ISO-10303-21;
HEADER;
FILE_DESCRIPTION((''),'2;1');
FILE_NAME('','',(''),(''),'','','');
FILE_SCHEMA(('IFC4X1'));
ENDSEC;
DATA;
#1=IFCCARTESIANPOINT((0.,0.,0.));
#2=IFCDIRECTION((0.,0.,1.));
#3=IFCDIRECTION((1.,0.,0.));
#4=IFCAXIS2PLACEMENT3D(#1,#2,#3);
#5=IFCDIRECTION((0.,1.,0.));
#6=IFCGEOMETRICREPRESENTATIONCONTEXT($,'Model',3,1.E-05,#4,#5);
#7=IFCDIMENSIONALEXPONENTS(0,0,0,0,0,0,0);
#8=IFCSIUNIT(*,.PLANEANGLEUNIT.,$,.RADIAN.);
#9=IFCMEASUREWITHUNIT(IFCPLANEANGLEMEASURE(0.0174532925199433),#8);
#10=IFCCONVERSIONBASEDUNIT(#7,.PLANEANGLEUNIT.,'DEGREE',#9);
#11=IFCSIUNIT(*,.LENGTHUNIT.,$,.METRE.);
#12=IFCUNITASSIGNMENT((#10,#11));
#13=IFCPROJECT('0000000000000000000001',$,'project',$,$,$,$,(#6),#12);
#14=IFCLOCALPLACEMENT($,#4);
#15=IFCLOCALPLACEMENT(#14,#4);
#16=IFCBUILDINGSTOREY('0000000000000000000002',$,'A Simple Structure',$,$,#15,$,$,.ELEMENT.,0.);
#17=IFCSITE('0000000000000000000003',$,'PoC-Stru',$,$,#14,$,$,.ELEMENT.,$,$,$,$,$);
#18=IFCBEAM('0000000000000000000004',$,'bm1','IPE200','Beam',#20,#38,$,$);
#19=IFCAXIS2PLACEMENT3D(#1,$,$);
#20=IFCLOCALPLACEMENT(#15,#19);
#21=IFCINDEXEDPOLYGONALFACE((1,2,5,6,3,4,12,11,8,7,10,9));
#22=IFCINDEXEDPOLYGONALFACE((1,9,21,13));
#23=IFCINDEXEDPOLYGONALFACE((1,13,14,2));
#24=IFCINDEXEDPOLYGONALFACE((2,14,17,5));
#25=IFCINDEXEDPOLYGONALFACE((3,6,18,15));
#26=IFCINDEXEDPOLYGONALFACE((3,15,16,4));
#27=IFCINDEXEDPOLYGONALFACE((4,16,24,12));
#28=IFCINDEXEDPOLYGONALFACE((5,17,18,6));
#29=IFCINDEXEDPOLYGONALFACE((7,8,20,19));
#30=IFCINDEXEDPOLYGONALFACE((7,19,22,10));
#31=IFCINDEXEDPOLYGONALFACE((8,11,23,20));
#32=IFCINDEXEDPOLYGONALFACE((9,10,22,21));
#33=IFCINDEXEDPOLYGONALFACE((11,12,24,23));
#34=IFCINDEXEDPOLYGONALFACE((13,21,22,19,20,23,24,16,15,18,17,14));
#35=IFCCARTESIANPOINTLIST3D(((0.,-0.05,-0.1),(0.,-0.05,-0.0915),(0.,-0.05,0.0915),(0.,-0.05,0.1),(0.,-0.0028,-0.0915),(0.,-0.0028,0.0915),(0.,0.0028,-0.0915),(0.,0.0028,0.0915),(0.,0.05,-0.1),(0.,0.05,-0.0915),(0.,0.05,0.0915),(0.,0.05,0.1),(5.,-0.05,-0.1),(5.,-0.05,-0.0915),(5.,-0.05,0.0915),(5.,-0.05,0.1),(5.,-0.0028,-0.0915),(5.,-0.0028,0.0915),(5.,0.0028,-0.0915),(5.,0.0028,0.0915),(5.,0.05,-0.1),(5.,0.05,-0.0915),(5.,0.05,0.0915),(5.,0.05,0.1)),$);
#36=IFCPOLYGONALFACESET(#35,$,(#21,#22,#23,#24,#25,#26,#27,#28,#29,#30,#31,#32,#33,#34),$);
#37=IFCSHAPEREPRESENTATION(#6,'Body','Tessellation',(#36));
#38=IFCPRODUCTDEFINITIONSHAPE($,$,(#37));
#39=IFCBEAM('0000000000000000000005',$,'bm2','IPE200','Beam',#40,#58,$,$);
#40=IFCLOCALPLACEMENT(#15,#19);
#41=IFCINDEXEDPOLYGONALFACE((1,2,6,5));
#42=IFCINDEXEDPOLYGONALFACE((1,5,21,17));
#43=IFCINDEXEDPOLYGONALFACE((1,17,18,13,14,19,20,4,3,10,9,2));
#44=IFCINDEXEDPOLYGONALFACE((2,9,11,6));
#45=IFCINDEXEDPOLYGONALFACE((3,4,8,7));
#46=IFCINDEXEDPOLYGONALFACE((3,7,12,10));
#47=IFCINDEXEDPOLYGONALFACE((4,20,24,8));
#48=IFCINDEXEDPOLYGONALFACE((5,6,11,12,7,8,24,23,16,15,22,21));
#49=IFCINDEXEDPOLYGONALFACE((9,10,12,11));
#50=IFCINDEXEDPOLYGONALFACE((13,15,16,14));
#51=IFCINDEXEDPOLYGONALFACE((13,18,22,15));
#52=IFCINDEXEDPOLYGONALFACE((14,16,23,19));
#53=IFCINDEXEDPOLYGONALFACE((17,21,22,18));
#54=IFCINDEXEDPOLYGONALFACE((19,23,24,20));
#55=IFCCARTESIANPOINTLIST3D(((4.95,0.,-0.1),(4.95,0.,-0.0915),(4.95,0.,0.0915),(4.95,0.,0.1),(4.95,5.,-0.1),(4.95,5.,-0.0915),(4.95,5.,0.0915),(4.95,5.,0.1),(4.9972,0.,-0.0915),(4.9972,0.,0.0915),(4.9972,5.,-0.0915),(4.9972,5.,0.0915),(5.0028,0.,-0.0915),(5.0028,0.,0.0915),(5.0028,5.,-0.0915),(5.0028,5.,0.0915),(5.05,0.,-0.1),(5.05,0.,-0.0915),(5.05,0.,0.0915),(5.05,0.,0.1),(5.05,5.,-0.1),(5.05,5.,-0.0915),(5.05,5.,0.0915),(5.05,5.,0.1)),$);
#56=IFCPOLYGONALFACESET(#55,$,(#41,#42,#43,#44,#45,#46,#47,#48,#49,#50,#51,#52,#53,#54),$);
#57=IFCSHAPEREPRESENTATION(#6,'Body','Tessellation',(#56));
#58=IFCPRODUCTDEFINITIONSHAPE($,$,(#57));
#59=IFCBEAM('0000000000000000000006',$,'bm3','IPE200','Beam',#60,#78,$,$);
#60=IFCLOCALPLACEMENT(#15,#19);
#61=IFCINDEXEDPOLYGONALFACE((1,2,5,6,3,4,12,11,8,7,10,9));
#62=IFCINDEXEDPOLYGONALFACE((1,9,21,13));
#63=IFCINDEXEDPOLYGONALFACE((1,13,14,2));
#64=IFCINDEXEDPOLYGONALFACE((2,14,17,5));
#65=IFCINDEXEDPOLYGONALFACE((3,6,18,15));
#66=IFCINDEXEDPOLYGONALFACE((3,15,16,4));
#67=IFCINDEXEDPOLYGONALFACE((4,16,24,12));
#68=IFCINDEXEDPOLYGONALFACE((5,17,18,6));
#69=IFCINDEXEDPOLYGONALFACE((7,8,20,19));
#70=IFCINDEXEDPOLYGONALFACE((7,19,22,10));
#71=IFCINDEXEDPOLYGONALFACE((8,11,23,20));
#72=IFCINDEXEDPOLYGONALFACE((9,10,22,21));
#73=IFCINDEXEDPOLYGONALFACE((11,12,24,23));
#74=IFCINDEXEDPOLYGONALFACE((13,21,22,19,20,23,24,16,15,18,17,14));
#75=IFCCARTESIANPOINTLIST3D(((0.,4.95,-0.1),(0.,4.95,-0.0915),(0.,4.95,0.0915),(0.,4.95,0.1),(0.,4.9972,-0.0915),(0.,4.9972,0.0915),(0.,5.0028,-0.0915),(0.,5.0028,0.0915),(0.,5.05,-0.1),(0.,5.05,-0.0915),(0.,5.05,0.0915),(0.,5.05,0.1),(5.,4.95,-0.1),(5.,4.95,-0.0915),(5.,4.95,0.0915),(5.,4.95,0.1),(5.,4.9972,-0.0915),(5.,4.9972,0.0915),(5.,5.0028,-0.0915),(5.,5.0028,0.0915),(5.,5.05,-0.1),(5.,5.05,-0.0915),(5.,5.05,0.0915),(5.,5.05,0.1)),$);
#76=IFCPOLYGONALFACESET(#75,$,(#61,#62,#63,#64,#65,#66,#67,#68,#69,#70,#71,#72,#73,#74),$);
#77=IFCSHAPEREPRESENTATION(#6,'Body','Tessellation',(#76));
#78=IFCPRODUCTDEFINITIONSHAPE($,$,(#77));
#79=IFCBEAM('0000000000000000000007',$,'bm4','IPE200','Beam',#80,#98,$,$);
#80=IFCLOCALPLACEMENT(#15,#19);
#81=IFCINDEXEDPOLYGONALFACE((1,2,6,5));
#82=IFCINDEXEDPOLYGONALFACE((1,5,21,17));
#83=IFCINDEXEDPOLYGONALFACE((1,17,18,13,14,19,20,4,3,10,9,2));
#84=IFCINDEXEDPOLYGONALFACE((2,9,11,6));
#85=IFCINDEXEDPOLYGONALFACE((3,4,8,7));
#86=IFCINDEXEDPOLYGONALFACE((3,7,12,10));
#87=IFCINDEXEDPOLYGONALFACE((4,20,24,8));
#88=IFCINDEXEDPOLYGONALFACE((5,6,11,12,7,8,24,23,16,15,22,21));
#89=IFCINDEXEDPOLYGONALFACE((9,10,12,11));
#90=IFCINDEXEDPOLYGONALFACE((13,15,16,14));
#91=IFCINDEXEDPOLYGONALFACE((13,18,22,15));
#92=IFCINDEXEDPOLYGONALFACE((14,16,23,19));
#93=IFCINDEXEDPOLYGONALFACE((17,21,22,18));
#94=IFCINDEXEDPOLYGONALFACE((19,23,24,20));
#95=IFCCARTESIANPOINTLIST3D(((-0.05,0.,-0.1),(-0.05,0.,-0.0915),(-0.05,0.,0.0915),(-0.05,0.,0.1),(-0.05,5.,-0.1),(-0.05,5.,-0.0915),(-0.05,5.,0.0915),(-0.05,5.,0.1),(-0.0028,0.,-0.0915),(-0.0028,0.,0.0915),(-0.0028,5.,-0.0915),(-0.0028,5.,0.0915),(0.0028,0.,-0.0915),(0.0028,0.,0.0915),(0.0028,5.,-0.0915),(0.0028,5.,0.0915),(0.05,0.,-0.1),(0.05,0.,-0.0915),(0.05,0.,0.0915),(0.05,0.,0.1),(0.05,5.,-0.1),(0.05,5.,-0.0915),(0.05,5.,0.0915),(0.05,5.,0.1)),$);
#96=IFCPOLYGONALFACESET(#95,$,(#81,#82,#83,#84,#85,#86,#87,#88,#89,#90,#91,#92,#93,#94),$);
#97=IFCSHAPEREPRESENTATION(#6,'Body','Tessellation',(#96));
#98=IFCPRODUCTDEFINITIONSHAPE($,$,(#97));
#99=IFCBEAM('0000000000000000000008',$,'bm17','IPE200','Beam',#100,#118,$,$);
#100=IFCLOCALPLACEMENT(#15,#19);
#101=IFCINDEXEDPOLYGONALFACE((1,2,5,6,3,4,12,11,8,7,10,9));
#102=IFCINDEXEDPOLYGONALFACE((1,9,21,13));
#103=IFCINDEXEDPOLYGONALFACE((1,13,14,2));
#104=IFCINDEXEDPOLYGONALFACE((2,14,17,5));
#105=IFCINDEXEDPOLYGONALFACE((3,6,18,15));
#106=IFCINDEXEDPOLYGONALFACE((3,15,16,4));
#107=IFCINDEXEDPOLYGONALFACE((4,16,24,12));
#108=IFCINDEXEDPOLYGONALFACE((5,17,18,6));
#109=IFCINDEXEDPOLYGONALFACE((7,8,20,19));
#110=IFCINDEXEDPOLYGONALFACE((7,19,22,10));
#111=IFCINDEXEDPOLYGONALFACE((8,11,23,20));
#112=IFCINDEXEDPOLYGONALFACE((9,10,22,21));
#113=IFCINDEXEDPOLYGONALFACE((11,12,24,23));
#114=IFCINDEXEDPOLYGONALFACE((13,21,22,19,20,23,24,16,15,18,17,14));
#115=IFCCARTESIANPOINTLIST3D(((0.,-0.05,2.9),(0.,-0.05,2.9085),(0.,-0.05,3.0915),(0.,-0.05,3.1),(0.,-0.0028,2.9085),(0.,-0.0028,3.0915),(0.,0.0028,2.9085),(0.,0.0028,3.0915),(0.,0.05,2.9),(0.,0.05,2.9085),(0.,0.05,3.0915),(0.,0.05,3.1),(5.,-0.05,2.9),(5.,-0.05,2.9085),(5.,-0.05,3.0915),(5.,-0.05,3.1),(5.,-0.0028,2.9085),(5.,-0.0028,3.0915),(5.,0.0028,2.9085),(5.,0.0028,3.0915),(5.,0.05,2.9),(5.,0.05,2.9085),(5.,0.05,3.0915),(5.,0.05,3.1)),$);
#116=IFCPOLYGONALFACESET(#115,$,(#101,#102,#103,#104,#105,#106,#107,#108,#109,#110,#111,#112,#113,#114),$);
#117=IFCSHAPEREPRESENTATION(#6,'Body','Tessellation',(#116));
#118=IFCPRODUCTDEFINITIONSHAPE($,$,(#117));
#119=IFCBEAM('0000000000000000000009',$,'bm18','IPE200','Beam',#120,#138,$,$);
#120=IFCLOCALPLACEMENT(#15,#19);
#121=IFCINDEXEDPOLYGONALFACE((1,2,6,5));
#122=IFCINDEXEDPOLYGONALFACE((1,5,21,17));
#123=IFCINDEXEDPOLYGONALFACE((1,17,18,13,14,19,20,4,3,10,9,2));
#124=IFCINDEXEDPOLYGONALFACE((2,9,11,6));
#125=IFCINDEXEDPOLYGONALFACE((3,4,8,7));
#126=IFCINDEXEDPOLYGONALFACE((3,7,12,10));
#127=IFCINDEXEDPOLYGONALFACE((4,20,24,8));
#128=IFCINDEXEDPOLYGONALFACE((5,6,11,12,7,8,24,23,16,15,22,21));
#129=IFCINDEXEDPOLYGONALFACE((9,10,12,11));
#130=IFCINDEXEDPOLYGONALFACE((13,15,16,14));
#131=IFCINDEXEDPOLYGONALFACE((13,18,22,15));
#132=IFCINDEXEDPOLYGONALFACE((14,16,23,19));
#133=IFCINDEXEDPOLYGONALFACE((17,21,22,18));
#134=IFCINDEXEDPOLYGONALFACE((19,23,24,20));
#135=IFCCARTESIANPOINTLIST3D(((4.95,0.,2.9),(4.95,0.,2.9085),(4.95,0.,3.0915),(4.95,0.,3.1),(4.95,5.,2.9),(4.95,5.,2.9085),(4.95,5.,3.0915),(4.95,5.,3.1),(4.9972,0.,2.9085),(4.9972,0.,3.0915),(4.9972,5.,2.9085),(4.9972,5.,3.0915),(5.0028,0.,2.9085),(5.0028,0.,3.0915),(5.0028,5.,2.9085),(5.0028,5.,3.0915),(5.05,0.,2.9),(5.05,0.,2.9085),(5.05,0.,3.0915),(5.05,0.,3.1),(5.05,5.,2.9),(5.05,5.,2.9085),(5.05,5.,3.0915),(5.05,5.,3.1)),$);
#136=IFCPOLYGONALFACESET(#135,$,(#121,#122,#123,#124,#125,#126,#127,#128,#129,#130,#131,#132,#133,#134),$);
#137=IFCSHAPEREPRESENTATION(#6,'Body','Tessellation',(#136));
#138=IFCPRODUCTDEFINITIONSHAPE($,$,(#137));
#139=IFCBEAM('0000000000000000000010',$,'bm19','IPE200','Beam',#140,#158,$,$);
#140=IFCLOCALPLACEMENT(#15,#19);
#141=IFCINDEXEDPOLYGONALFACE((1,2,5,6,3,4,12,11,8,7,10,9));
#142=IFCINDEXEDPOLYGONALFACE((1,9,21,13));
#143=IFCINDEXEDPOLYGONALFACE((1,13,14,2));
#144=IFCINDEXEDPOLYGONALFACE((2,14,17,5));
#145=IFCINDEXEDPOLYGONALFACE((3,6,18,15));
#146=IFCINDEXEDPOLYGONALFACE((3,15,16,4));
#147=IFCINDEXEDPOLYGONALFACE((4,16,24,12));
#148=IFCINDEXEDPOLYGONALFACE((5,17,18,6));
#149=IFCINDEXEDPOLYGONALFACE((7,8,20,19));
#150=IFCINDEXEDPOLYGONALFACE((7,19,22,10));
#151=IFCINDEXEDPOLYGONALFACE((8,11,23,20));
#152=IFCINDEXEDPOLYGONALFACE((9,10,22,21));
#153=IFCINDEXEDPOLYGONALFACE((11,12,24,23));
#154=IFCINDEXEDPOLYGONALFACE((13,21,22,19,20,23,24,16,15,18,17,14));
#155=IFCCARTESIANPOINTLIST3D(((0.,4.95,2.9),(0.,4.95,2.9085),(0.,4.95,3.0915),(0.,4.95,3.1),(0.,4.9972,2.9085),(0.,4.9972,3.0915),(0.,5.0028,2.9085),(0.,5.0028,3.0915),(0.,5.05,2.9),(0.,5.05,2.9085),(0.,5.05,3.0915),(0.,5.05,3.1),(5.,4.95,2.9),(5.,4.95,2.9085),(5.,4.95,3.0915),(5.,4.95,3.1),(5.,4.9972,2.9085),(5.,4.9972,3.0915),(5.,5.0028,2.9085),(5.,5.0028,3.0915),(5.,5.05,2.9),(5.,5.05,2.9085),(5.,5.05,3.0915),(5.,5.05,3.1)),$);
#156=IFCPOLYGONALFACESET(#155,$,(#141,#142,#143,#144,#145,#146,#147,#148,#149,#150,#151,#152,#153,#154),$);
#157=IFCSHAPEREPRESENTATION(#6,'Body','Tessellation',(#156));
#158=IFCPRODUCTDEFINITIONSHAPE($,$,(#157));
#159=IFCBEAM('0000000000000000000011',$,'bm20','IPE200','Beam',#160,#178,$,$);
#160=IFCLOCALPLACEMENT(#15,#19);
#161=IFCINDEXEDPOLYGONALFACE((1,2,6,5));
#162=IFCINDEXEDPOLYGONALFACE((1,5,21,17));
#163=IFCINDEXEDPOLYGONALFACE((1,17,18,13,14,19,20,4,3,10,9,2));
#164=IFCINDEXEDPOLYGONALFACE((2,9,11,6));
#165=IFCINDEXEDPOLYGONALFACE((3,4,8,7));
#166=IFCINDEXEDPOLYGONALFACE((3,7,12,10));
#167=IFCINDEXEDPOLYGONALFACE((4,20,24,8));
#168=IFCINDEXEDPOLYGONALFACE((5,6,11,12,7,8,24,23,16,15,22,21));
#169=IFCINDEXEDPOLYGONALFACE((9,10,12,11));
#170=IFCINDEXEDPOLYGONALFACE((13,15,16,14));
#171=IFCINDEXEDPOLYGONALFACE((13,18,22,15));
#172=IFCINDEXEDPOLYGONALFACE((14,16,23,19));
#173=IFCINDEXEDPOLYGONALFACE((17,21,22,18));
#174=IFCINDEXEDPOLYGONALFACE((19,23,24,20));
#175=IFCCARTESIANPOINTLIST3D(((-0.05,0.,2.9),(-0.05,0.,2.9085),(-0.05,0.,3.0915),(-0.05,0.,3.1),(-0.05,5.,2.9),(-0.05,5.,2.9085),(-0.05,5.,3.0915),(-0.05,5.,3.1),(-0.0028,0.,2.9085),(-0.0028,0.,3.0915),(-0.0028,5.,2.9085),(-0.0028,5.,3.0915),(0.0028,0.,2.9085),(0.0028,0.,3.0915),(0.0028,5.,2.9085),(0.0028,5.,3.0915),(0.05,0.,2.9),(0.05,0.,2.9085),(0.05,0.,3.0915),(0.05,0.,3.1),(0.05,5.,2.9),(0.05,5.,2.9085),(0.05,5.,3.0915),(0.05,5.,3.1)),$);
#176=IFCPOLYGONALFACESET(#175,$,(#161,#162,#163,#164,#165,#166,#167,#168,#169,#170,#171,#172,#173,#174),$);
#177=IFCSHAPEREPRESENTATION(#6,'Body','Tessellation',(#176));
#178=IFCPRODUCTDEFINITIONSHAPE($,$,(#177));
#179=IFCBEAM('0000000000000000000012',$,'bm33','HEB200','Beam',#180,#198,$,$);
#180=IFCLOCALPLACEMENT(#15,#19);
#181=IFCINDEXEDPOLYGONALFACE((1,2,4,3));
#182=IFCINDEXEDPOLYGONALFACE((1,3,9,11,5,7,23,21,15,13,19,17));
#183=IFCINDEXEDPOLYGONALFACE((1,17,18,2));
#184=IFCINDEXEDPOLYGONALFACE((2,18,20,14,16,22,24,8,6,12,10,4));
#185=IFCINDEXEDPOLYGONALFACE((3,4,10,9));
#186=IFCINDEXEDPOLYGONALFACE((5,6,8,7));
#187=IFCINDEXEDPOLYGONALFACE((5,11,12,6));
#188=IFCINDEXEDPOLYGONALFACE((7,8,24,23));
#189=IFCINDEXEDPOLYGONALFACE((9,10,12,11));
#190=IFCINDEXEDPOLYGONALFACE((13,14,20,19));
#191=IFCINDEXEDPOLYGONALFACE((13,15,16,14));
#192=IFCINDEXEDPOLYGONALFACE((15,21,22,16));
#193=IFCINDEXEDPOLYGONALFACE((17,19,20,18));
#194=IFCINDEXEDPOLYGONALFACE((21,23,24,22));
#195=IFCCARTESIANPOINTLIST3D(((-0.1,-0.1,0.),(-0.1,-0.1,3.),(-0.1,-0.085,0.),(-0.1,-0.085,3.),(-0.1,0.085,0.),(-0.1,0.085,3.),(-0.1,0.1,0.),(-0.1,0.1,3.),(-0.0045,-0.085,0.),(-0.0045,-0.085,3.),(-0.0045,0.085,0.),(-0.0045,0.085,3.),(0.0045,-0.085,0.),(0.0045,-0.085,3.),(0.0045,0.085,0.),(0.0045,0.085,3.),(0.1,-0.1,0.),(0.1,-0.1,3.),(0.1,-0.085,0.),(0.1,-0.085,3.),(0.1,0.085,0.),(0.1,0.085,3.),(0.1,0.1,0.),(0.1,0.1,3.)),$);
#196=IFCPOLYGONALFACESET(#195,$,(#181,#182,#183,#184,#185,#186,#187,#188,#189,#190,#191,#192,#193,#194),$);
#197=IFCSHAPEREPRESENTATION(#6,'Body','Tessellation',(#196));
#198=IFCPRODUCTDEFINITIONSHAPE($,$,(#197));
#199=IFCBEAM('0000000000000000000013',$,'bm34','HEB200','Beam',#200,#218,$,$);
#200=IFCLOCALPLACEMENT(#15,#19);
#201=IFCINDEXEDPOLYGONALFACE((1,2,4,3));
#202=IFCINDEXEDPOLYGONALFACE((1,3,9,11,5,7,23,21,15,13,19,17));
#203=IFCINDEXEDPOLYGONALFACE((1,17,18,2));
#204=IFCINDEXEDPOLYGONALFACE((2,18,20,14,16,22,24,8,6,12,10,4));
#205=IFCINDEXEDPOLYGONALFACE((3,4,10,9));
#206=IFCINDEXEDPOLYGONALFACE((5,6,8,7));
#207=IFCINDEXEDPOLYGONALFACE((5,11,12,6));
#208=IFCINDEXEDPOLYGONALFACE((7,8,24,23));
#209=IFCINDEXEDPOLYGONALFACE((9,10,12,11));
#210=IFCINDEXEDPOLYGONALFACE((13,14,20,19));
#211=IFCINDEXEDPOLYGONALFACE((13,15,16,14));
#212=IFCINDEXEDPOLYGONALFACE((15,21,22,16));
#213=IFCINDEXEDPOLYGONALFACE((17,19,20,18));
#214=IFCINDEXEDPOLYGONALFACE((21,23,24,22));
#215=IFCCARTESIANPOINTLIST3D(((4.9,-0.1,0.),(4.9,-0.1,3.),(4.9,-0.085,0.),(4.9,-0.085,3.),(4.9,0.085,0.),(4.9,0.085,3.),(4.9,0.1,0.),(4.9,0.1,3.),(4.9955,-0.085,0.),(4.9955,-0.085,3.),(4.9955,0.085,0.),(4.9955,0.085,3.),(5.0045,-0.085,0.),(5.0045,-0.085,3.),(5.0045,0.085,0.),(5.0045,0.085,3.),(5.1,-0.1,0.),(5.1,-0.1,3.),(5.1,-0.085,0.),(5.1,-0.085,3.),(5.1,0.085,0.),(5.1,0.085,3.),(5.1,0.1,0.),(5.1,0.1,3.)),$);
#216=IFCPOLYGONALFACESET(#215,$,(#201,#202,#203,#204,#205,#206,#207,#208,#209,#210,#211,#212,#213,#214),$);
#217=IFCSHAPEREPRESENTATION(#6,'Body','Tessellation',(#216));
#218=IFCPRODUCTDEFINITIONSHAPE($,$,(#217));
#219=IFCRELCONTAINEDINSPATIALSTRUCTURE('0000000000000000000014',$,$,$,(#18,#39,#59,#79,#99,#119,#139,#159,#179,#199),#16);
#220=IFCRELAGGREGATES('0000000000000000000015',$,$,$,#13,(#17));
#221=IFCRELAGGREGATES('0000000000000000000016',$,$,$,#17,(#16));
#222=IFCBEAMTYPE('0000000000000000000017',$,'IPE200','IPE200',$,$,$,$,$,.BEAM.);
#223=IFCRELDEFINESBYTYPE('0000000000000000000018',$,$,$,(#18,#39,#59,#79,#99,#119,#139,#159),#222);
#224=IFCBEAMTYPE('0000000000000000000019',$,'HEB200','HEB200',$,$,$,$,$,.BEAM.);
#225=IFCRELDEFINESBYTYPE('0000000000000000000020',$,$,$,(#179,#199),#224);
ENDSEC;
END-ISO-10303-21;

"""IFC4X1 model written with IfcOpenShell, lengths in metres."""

from ifc_helpers import new_model, entity, si_unit, converted_unit, direction, frame, origin, origin_with_axes, place, context, project, spatial, i_section, extrude, type_object, element, save


model = new_model("IFC4X1")

# Units and contexts
model_context = context("Model", 3, precision=1e-05, world=origin_with_axes(), true_north=direction((0.0, 1.0, 0.0)))
ifc_project = project(units=[converted_unit("PLANEANGLEUNIT", "DEGREE", entity("IfcPlaneAngleMeasure", 0.0174532925199433), si_unit("PLANEANGLEUNIT", "RADIAN"), dimensions=[0, 0, 0, 0, 0, 0, 0]), si_unit("LENGTHUNIT", "METRE")], contexts=[model_context])

# Site, storey
site_placement = place(None, origin_with_axes())
site = spatial("IfcSite", under=ifc_project, at=site_placement, Name="PoC-Stru", CompositionType="ELEMENT")
storey_placement = place(site_placement, origin_with_axes())
storey = spatial("IfcBuildingStorey", under=site, at=storey_placement, Name="A Simple Structure", CompositionType="ELEMENT", Elevation=0.0)

# Beams
beam_type_1 = type_object("IfcBeamType", Name="IPE200", Description="IPE200", PredefinedType="BEAM")
placement = place(storey_placement, origin_with_axes())
for number, where, z_axis, x_axis, name in (
    (1, (0.0, 0.0, 0.0), (1.0, 0.0, 0.0), (0.0, 1.0, 0.0), "bm1"),
    (2, (5.0, 0.0, 0.0), (0.0, 1.0, 0.0), (-1.0, 0.0, 0.0), "bm2"),
    (3, (5.0, 5.0, 0.0), (-1.0, 0.0, 0.0), (0.0, -1.0, 0.0), "bm3"),
    (4, (0.0, 5.0, 0.0), (0.0, -1.0, 0.0), (1.0, 0.0, 0.0), "bm4"),
    (5, (0.0, 0.0, 3.0), (1.0, 0.0, 0.0), (0.0, 1.0, 0.0), "bm17"),
    (6, (5.0, 0.0, 3.0), (0.0, 1.0, 0.0), (-1.0, 0.0, 0.0), "bm18"),
    (7, (5.0, 5.0, 3.0), (-1.0, 0.0, 0.0), (0.0, -1.0, 0.0), "bm19"),
    (8, (0.0, 5.0, 3.0), (0.0, -1.0, 0.0), (1.0, 0.0, 0.0), "bm20"),
):
    element("IfcBeam", number, at=place(placement, frame(where, z_axis=z_axis, x_axis=x_axis)), inside=storey, type_object=beam_type_1, Name=name, Description="IPE200", ObjectType="Beam", context=model_context, shape_type="SweptSolid", body=[
        extrude(i_section(OverallWidth=0.1, OverallDepth=0.2, WebThickness=0.0056, FlangeThickness=0.0085), origin(), (0.0, 0.0, 1.0), 5.0),
    ])
beam_type_2 = type_object("IfcBeamType", Name="HEB200", Description="HEB200", PredefinedType="BEAM")
beam_placement = place(placement, origin_with_axes())
element("IfcBeam", 9, at=beam_placement, inside=storey, type_object=beam_type_2, Name="bm33", Description="HEB200", ObjectType="Beam", context=model_context, shape_type="SweptSolid", body=[
    extrude(i_section(OverallWidth=0.2, OverallDepth=0.2, WebThickness=0.009, FlangeThickness=0.015), origin(), (0.0, 0.0, 1.0), 3.0),
])
for number, where, z_axis, x_axis, name in (
    (10, (5.0, 0.0, 0.0), (0.0, 0.0, 1.0), (1.0, 0.0, 0.0), "bm34"),
):
    element("IfcBeam", number, at=place(placement, frame(where, z_axis=z_axis, x_axis=x_axis)), inside=storey, type_object=beam_type_2, Name=name, Description="HEB200", ObjectType="Beam", context=model_context, shape_type="SweptSolid", body=[
        extrude(i_section(OverallWidth=0.2, OverallDepth=0.2, WebThickness=0.009, FlangeThickness=0.015), origin(), (0.0, 0.0, 1.0), 3.0),
    ])

save(model, "model.ifc")
